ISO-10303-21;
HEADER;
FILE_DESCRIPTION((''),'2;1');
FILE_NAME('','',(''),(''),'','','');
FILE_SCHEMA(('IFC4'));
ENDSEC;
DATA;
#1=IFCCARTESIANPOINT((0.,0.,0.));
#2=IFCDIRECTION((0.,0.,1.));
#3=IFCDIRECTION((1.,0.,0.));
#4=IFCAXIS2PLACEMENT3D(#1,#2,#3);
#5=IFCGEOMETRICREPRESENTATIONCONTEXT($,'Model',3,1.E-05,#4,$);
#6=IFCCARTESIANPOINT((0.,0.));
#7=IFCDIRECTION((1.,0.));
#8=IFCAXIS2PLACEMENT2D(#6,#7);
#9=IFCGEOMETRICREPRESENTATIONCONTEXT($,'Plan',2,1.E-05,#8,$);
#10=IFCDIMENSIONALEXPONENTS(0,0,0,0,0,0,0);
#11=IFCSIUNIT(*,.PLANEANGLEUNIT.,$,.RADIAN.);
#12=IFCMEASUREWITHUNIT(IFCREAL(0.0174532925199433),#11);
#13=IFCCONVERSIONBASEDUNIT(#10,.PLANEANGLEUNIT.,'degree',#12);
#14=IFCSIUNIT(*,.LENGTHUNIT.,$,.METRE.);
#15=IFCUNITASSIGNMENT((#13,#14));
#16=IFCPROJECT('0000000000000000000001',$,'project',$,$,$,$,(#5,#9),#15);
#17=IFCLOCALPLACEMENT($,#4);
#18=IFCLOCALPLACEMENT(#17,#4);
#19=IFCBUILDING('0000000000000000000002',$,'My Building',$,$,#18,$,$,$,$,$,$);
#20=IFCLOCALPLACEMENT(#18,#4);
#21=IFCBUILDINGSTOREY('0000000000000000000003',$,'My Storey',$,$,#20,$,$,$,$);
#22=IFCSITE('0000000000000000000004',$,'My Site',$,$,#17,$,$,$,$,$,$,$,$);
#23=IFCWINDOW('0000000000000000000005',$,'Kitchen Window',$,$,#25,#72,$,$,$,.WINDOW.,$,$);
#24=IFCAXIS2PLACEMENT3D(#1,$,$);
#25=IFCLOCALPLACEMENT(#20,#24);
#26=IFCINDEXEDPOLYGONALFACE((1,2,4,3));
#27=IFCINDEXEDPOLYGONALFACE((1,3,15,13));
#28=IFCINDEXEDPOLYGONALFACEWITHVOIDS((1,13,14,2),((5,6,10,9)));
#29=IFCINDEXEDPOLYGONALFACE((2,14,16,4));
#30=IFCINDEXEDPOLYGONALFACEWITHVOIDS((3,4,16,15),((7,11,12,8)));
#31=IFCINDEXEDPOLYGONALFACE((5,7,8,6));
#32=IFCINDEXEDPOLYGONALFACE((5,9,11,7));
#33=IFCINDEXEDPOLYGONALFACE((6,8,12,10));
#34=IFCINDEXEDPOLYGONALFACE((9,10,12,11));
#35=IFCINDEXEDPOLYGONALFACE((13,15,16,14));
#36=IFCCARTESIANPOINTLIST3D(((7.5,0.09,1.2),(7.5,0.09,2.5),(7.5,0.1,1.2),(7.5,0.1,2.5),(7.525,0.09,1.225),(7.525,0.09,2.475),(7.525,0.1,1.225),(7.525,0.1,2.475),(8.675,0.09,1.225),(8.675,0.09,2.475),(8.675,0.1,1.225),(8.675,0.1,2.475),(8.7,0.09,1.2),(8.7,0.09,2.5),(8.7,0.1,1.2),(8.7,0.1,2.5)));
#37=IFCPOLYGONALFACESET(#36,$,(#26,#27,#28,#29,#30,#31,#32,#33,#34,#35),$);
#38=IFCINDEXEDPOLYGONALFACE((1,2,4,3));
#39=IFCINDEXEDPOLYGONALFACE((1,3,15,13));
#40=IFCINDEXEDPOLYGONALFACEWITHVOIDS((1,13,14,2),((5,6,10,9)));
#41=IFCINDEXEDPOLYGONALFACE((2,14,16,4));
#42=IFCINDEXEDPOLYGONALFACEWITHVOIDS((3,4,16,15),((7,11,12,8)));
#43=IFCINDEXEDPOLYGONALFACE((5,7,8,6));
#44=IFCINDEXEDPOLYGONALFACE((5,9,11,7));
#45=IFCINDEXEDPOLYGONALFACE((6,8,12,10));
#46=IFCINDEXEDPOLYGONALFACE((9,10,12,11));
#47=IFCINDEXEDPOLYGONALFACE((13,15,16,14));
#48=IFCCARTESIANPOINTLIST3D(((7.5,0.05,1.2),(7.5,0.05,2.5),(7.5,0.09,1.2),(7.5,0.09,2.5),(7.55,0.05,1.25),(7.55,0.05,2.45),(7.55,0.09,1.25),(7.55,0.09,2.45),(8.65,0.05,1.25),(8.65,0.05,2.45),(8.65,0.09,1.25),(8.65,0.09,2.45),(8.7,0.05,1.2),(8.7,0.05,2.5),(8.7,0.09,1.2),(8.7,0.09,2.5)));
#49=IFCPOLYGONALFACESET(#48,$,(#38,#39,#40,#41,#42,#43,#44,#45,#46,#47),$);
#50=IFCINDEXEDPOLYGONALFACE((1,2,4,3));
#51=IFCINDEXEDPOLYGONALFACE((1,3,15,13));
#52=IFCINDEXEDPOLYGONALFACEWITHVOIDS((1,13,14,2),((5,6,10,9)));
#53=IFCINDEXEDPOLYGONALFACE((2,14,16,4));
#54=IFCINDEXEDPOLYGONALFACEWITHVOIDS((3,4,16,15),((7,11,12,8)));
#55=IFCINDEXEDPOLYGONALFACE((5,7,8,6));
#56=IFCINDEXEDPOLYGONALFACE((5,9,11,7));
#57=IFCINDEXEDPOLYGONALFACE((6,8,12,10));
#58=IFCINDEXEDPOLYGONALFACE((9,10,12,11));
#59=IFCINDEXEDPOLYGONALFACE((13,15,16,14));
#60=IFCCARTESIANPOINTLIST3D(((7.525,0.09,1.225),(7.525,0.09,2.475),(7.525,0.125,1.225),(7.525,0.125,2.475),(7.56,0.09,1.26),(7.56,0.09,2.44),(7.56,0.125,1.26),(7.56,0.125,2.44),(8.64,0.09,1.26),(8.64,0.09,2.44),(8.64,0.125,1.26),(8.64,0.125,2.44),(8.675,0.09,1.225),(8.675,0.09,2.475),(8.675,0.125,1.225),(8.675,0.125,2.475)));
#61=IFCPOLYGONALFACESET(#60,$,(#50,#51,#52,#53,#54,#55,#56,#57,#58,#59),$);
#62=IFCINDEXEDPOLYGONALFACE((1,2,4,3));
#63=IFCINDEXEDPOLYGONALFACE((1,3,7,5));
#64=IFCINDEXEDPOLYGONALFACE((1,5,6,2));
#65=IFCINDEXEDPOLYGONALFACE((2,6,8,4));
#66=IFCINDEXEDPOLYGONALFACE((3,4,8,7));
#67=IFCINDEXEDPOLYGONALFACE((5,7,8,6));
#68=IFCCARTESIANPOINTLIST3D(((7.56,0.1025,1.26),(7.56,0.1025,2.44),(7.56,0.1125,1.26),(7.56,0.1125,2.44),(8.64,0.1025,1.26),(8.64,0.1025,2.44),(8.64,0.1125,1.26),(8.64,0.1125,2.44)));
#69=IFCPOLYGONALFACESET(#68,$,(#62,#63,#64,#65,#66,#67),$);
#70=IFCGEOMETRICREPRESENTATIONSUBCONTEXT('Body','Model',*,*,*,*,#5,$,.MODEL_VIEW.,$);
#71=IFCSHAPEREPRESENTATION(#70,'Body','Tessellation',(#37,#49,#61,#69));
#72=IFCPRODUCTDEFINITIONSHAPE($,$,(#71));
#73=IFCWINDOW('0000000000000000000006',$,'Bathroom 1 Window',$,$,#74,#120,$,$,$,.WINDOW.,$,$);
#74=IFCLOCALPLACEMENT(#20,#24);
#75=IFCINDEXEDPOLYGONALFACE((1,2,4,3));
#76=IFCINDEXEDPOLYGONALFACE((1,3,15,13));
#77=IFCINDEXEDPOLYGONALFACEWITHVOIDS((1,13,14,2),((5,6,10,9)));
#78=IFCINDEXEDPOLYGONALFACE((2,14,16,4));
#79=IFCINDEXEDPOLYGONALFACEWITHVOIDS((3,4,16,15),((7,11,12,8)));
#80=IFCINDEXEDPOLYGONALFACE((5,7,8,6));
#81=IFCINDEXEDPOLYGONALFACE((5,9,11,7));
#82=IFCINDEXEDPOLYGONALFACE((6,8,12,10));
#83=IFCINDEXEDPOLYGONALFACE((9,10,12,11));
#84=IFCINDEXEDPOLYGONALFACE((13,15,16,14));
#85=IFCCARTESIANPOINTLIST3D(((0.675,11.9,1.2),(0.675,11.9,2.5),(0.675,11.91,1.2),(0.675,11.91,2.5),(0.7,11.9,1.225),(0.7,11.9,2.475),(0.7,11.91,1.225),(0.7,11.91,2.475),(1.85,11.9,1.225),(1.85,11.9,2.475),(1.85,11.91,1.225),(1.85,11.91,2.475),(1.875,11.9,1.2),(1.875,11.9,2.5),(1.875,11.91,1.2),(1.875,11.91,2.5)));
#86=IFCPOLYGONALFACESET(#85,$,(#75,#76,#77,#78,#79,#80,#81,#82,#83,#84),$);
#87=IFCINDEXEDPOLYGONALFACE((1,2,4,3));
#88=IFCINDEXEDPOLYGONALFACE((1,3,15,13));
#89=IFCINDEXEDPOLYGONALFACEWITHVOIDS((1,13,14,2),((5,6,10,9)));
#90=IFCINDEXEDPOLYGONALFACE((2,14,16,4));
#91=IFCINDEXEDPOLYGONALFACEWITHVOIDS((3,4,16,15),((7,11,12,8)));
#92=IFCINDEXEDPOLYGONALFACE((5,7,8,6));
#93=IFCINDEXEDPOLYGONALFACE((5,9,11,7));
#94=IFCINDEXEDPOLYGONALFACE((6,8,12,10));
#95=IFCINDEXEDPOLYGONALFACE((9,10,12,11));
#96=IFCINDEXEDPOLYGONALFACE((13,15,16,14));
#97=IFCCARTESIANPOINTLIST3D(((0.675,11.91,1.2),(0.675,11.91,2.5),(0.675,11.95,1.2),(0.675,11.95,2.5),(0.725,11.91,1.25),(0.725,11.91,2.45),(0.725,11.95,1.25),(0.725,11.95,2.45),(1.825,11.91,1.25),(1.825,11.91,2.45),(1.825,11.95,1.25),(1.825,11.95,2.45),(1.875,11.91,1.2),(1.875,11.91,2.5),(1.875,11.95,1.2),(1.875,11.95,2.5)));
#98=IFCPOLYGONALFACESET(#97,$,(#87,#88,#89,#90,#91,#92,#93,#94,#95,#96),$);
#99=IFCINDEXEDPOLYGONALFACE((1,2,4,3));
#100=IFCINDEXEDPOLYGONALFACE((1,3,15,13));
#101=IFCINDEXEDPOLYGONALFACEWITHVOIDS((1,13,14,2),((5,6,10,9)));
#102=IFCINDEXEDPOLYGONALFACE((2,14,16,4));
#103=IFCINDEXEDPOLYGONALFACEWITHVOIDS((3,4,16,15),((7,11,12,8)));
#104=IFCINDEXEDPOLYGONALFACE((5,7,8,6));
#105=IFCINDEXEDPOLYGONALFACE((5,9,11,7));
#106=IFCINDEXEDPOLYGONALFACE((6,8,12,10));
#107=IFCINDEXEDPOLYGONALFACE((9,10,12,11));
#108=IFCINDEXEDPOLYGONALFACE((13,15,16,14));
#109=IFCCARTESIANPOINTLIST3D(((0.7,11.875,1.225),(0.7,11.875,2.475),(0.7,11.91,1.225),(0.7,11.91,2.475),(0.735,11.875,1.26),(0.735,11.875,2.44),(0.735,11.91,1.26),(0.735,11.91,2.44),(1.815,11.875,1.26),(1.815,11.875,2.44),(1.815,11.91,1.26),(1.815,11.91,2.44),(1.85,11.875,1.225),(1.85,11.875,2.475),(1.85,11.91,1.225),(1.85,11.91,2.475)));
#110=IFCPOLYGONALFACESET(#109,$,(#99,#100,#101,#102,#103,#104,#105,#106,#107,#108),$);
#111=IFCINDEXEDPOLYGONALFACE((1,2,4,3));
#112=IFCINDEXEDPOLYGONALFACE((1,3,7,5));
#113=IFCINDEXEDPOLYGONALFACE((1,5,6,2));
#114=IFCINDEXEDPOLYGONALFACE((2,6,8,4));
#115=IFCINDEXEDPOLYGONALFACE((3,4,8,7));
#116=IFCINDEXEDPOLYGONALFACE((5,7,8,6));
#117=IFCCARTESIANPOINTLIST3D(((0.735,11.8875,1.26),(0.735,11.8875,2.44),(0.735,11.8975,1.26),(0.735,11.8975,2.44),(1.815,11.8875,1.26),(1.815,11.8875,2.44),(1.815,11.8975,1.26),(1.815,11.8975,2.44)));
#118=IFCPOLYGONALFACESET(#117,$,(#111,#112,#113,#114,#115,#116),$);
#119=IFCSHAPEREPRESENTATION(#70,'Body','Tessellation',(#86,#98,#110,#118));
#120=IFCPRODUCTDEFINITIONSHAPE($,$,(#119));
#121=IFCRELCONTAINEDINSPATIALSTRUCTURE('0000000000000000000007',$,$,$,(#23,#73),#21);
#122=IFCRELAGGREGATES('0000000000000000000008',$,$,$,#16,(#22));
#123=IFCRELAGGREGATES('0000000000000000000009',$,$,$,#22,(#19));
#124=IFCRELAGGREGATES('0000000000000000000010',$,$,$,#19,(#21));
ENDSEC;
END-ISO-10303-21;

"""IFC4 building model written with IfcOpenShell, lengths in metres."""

from ifc_helpers import new_model, entity, si_unit, converted_unit, frame, origin_with_axes, origin_2d_with_axis, place, context, subcontext, project, spatial, line, indexed_curve, outline, extrude, element, save


model = new_model("IFC4")

# Units and contexts
model_context = context("Model", 3, precision=1e-05, world=origin_with_axes())
plan_context = context("Plan", 2, precision=1e-05, world=origin_2d_with_axis())
body_context = subcontext(model_context, "Body", "Model", "MODEL_VIEW")
ifc_project = project(units=[converted_unit("PLANEANGLEUNIT", "degree", entity("IfcReal", 0.0174532925199433), si_unit("PLANEANGLEUNIT", "RADIAN"), dimensions=[0, 0, 0, 0, 0, 0, 0]), si_unit("LENGTHUNIT", "METRE")], contexts=[model_context, plan_context])

# Site, building, storey
site_placement = place(None, origin_with_axes())
site = spatial("IfcSite", under=ifc_project, at=site_placement, Name="My Site")
building_placement = place(site_placement, origin_with_axes())
building = spatial("IfcBuilding", under=site, at=building_placement, Name="My Building")
storey_placement = place(building_placement, origin_with_axes())
storey = spatial("IfcBuildingStorey", under=building, at=storey_placement, Name="My Storey")

# Windows
for number, where, z_axis, x_axis, name in (
    (1, (7.5, 0.0, 1.2), (0.0, 0.0, 1.0), (1.0, 0.0, 0.0), "Kitchen Window"),
    (2, (1.875, 12.0, 1.2), (0.0, 0.0, 1.0), (-1.0, 0.0, 0.0), "Bathroom 1 Window"),
):
    element("IfcWindow", number, at=place(storey_placement, frame(where, z_axis=z_axis, x_axis=x_axis)), inside=storey, Name=name, PredefinedType="WINDOW", context=body_context, shape_type="SweptSolid", body=[
        extrude(outline(indexed_curve([(0.0, 0.0), (1.2, 0.0), (1.2, 1.3), (0.0, 1.3)], segments=[line(1, 2, 3, 4, 1)]), holes=[indexed_curve([(0.025, 0.025), (1.175, 0.025), (1.175, 1.275), (0.025, 1.275)], segments=[line(1, 2, 3, 4, 1)])]), frame((0.0, 0.09, 0.0), z_axis=(0.0, -1.0, 0.0), x_axis=(1.0, 0.0, 0.0)), (0.0, 0.0, -1.0), 0.01),
        extrude(outline(indexed_curve([(0.0, 0.0), (1.2, 0.0), (1.2, 1.3), (0.0, 1.3)], segments=[line(1, 2, 3, 4, 1)]), holes=[indexed_curve([(0.05, 0.05), (1.15, 0.05), (1.15, 1.25), (0.05, 1.25)], segments=[line(1, 2, 3, 4, 1)])]), frame((0.0, 0.05, 0.0), z_axis=(0.0, -1.0, 0.0), x_axis=(1.0, 0.0, 0.0)), (0.0, 0.0, -1.0), 0.04),
        extrude(outline(indexed_curve([(0.0, 0.0), (1.15, 0.0), (1.15, 1.25), (0.0, 1.25)], segments=[line(1, 2, 3, 4, 1)]), holes=[indexed_curve([(0.035, 0.035), (1.115, 0.035), (1.115, 1.215), (0.035, 1.215)], segments=[line(1, 2, 3, 4, 1)])]), frame((0.025, 0.09, 0.025), z_axis=(0.0, -1.0, 0.0), x_axis=(1.0, 0.0, 0.0)), (0.0, 0.0, -1.0), 0.035),
        extrude(outline(indexed_curve([(0.035, 0.035), (1.115, 0.035), (1.115, 1.215), (0.035, 1.215)], segments=[line(1, 2, 3, 4, 1)])), frame((0.025, 0.1025, 0.025), z_axis=(0.0, -1.0, 0.0), x_axis=(1.0, 0.0, 0.0)), (0.0, 0.0, -1.0), 0.01),
    ])

save(model, "model.ifc")
